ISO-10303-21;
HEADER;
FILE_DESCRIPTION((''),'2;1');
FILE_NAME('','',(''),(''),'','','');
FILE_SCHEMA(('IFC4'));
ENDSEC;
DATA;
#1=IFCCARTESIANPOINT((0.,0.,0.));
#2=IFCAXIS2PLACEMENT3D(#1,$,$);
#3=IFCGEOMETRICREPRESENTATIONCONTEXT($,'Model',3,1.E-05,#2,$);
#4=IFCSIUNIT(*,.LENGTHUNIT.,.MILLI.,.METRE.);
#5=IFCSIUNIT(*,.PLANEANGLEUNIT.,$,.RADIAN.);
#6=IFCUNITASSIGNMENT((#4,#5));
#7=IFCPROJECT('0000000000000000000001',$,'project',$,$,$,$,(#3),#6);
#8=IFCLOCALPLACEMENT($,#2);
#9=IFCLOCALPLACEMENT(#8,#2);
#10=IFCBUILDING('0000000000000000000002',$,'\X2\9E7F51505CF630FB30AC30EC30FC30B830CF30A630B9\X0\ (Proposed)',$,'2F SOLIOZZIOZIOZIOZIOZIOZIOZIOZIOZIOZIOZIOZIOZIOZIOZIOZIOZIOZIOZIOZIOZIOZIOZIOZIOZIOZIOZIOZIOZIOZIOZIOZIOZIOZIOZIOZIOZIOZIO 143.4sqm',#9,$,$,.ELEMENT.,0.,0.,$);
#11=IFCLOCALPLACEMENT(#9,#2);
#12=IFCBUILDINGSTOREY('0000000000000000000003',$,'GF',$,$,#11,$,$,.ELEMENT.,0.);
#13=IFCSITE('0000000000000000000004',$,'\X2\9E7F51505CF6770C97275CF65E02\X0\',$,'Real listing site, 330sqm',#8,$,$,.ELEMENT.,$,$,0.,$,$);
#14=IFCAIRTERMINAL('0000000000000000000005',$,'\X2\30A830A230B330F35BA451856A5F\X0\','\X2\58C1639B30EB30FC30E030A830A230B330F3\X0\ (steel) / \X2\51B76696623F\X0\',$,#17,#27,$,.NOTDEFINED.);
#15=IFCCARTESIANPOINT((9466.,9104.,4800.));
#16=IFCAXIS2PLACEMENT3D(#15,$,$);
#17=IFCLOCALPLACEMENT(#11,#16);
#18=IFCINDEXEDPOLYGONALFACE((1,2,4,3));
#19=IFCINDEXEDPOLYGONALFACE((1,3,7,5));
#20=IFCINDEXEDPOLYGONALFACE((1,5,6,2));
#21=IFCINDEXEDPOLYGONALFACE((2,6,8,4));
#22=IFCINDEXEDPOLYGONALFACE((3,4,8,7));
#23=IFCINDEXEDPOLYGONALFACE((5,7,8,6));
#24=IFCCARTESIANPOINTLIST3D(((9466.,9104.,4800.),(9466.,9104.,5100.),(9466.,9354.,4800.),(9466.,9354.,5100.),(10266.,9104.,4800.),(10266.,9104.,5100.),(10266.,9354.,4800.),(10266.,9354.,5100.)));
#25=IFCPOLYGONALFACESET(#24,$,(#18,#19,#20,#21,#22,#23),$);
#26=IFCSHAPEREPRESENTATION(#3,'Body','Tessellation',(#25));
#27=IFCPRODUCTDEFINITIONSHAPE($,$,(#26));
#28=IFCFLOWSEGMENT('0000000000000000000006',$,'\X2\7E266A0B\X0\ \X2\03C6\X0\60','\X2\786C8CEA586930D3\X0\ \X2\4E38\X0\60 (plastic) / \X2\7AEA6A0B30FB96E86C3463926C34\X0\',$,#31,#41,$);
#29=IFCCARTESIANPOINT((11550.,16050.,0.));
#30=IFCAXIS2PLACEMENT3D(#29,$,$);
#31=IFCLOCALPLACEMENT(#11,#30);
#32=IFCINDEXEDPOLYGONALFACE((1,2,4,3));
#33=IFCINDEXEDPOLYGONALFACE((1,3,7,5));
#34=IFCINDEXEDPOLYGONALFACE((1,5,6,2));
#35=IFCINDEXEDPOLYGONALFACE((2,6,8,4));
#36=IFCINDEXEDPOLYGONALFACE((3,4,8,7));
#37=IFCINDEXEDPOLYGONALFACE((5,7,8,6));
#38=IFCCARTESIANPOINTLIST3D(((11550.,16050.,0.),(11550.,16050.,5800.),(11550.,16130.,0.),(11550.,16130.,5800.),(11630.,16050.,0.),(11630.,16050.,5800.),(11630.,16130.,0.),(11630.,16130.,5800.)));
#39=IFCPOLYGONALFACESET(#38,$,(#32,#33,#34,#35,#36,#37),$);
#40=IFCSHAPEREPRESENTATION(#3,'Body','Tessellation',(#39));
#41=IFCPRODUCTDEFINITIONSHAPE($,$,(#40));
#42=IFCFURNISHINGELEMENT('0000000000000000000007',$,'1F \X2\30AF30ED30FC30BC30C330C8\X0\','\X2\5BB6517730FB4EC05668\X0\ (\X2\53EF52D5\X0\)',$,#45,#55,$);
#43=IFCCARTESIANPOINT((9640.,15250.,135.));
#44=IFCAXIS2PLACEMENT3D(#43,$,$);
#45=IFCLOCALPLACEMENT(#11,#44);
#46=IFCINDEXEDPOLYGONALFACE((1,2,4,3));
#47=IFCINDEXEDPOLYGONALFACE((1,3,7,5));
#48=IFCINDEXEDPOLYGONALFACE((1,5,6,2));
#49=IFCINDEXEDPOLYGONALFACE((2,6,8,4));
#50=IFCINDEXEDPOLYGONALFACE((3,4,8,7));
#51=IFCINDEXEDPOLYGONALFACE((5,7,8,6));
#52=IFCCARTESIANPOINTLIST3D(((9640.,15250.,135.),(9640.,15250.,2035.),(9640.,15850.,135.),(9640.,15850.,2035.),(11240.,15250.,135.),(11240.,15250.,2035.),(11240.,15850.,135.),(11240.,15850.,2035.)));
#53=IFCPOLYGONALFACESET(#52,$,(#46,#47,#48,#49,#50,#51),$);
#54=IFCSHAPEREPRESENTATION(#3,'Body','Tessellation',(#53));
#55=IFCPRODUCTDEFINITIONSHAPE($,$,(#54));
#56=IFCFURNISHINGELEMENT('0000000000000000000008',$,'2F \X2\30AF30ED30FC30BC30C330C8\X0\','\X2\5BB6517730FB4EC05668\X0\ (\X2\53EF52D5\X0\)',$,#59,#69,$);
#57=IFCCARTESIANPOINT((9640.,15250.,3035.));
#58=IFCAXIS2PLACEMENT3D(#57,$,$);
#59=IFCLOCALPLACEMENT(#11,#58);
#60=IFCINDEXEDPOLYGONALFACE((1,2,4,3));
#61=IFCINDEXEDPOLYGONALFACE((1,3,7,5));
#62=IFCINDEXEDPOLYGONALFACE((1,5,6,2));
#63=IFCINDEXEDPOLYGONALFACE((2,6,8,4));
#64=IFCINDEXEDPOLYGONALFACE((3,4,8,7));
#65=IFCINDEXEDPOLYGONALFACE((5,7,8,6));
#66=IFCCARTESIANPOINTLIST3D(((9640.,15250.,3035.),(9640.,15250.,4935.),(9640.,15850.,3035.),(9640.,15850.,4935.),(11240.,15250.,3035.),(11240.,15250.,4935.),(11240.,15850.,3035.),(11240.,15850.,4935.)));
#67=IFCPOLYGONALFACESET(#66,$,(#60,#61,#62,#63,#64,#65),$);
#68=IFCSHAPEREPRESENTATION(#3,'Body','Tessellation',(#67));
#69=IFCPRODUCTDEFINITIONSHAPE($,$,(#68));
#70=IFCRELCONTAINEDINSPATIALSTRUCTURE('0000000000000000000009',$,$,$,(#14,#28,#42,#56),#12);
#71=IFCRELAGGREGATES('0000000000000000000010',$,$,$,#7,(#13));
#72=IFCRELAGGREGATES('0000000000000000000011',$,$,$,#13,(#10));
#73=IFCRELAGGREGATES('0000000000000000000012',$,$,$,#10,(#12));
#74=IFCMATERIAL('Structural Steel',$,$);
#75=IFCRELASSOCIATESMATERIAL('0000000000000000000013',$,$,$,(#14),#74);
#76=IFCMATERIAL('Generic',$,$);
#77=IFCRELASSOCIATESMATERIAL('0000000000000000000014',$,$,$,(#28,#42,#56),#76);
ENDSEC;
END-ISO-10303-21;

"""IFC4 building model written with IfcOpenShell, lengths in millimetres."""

from ifc_helpers import new_model, si_unit, frame, frame_2d, origin, place, context, project, spatial, rectangle, extrude, material, element, save


model = new_model("IFC4")

# Units and contexts
model_context = context("Model", 3, precision=1e-05, world=origin())
ifc_project = project(units=[si_unit("LENGTHUNIT", "METRE", prefix="MILLI"), si_unit("PLANEANGLEUNIT", "RADIAN")], contexts=[model_context])

# Site, building, storey
site_placement = place(None, origin())
site = spatial("IfcSite", under=ifc_project, at=site_placement, Name="鹿児島県霧島市", ObjectType="Real listing site, 330sqm", CompositionType="ELEMENT", RefElevation=0.0)
building_placement = place(site_placement, origin())
building = spatial("IfcBuilding", under=site, at=building_placement, Name="鹿児島・ガレージハウス (Proposed)", ObjectType="2F SOLIOZZIOZIOZIOZIOZIOZIOZIOZIOZIOZIOZIOZIOZIOZIOZIOZIOZIOZIOZIOZIOZIOZIOZIOZIOZIOZIOZIOZIOZIOZIOZIOZIOZIOZIOZIOZIOZIOZIO 143.4sqm", CompositionType="ELEMENT", ElevationOfRefHeight=0.0, ElevationOfTerrain=0.0)
storey_placement = place(building_placement, origin())
storey = spatial("IfcBuildingStorey", under=building, at=storey_placement, Name="GF", CompositionType="ELEMENT", Elevation=0.0)

# Shared definitions
ifc_material_1 = material(Name="Structural Steel")

# Shared definitions
ifc_material_2 = material(Name="Generic")

# Air terminal
air_terminal_placement = place(storey_placement, frame((9466.0, 9104.0, 4800.0)))
element("IfcAirTerminal", 1, at=air_terminal_placement, inside=storey, material=ifc_material_1, Name="エアコン室内機", Description="壁掛ルームエアコン (steel) / 冷暖房", PredefinedType="NOTDEFINED", context=model_context, shape_type="SweptSolid", body=[
    extrude(rectangle(XDim=800.0, YDim=250.0, at=frame_2d((400.0, 125.0))), frame((9466.0, 9104.0, 4800.0)), (0.0, 0.0, 1.0), 300.0),
])

# Flow segment
flow_segment_placement = place(storey_placement, frame((11550.0, 16050.0, 0.0)))
element("IfcFlowSegment", 2, at=flow_segment_placement, inside=storey, material=ifc_material_2, Name="縦樋 φ60", Description="硬質塩ビ 丸60 (plastic) / 竪樋・雨水排水", context=model_context, shape_type="SweptSolid", body=[
    extrude(rectangle(XDim=80.0, YDim=80.0, at=frame_2d((40.0, 40.0))), frame((11550.0, 16050.0, 0.0)), (0.0, 0.0, 1.0), 5800.0),
])

# Furnishing elements
furnishing_1_placement = place(storey_placement, frame((9640.0, 15250.0, 135.0)))
element("IfcFurnishingElement", 3, at=furnishing_1_placement, inside=storey, material=ifc_material_2, Name="1F クローゼット", Description="家具・什器 (可動)", context=model_context, shape_type="SweptSolid", body=[
    extrude(rectangle(XDim=1600.0, YDim=600.0, at=frame_2d((800.0, 300.0))), frame((9640.0, 15250.0, 135.0)), (0.0, 0.0, 1.0), 1900.0),
])
furnishing_2_placement = place(storey_placement, frame((9640.0, 15250.0, 3035.0)))
element("IfcFurnishingElement", 4, at=furnishing_2_placement, inside=storey, material=ifc_material_2, Name="2F クローゼット", Description="家具・什器 (可動)", context=model_context, shape_type="SweptSolid", body=[
    extrude(rectangle(XDim=1600.0, YDim=600.0, at=frame_2d((800.0, 300.0))), frame((9640.0, 15250.0, 3035.0)), (0.0, 0.0, 1.0), 1900.0),
])

save(model, "model.ifc")
